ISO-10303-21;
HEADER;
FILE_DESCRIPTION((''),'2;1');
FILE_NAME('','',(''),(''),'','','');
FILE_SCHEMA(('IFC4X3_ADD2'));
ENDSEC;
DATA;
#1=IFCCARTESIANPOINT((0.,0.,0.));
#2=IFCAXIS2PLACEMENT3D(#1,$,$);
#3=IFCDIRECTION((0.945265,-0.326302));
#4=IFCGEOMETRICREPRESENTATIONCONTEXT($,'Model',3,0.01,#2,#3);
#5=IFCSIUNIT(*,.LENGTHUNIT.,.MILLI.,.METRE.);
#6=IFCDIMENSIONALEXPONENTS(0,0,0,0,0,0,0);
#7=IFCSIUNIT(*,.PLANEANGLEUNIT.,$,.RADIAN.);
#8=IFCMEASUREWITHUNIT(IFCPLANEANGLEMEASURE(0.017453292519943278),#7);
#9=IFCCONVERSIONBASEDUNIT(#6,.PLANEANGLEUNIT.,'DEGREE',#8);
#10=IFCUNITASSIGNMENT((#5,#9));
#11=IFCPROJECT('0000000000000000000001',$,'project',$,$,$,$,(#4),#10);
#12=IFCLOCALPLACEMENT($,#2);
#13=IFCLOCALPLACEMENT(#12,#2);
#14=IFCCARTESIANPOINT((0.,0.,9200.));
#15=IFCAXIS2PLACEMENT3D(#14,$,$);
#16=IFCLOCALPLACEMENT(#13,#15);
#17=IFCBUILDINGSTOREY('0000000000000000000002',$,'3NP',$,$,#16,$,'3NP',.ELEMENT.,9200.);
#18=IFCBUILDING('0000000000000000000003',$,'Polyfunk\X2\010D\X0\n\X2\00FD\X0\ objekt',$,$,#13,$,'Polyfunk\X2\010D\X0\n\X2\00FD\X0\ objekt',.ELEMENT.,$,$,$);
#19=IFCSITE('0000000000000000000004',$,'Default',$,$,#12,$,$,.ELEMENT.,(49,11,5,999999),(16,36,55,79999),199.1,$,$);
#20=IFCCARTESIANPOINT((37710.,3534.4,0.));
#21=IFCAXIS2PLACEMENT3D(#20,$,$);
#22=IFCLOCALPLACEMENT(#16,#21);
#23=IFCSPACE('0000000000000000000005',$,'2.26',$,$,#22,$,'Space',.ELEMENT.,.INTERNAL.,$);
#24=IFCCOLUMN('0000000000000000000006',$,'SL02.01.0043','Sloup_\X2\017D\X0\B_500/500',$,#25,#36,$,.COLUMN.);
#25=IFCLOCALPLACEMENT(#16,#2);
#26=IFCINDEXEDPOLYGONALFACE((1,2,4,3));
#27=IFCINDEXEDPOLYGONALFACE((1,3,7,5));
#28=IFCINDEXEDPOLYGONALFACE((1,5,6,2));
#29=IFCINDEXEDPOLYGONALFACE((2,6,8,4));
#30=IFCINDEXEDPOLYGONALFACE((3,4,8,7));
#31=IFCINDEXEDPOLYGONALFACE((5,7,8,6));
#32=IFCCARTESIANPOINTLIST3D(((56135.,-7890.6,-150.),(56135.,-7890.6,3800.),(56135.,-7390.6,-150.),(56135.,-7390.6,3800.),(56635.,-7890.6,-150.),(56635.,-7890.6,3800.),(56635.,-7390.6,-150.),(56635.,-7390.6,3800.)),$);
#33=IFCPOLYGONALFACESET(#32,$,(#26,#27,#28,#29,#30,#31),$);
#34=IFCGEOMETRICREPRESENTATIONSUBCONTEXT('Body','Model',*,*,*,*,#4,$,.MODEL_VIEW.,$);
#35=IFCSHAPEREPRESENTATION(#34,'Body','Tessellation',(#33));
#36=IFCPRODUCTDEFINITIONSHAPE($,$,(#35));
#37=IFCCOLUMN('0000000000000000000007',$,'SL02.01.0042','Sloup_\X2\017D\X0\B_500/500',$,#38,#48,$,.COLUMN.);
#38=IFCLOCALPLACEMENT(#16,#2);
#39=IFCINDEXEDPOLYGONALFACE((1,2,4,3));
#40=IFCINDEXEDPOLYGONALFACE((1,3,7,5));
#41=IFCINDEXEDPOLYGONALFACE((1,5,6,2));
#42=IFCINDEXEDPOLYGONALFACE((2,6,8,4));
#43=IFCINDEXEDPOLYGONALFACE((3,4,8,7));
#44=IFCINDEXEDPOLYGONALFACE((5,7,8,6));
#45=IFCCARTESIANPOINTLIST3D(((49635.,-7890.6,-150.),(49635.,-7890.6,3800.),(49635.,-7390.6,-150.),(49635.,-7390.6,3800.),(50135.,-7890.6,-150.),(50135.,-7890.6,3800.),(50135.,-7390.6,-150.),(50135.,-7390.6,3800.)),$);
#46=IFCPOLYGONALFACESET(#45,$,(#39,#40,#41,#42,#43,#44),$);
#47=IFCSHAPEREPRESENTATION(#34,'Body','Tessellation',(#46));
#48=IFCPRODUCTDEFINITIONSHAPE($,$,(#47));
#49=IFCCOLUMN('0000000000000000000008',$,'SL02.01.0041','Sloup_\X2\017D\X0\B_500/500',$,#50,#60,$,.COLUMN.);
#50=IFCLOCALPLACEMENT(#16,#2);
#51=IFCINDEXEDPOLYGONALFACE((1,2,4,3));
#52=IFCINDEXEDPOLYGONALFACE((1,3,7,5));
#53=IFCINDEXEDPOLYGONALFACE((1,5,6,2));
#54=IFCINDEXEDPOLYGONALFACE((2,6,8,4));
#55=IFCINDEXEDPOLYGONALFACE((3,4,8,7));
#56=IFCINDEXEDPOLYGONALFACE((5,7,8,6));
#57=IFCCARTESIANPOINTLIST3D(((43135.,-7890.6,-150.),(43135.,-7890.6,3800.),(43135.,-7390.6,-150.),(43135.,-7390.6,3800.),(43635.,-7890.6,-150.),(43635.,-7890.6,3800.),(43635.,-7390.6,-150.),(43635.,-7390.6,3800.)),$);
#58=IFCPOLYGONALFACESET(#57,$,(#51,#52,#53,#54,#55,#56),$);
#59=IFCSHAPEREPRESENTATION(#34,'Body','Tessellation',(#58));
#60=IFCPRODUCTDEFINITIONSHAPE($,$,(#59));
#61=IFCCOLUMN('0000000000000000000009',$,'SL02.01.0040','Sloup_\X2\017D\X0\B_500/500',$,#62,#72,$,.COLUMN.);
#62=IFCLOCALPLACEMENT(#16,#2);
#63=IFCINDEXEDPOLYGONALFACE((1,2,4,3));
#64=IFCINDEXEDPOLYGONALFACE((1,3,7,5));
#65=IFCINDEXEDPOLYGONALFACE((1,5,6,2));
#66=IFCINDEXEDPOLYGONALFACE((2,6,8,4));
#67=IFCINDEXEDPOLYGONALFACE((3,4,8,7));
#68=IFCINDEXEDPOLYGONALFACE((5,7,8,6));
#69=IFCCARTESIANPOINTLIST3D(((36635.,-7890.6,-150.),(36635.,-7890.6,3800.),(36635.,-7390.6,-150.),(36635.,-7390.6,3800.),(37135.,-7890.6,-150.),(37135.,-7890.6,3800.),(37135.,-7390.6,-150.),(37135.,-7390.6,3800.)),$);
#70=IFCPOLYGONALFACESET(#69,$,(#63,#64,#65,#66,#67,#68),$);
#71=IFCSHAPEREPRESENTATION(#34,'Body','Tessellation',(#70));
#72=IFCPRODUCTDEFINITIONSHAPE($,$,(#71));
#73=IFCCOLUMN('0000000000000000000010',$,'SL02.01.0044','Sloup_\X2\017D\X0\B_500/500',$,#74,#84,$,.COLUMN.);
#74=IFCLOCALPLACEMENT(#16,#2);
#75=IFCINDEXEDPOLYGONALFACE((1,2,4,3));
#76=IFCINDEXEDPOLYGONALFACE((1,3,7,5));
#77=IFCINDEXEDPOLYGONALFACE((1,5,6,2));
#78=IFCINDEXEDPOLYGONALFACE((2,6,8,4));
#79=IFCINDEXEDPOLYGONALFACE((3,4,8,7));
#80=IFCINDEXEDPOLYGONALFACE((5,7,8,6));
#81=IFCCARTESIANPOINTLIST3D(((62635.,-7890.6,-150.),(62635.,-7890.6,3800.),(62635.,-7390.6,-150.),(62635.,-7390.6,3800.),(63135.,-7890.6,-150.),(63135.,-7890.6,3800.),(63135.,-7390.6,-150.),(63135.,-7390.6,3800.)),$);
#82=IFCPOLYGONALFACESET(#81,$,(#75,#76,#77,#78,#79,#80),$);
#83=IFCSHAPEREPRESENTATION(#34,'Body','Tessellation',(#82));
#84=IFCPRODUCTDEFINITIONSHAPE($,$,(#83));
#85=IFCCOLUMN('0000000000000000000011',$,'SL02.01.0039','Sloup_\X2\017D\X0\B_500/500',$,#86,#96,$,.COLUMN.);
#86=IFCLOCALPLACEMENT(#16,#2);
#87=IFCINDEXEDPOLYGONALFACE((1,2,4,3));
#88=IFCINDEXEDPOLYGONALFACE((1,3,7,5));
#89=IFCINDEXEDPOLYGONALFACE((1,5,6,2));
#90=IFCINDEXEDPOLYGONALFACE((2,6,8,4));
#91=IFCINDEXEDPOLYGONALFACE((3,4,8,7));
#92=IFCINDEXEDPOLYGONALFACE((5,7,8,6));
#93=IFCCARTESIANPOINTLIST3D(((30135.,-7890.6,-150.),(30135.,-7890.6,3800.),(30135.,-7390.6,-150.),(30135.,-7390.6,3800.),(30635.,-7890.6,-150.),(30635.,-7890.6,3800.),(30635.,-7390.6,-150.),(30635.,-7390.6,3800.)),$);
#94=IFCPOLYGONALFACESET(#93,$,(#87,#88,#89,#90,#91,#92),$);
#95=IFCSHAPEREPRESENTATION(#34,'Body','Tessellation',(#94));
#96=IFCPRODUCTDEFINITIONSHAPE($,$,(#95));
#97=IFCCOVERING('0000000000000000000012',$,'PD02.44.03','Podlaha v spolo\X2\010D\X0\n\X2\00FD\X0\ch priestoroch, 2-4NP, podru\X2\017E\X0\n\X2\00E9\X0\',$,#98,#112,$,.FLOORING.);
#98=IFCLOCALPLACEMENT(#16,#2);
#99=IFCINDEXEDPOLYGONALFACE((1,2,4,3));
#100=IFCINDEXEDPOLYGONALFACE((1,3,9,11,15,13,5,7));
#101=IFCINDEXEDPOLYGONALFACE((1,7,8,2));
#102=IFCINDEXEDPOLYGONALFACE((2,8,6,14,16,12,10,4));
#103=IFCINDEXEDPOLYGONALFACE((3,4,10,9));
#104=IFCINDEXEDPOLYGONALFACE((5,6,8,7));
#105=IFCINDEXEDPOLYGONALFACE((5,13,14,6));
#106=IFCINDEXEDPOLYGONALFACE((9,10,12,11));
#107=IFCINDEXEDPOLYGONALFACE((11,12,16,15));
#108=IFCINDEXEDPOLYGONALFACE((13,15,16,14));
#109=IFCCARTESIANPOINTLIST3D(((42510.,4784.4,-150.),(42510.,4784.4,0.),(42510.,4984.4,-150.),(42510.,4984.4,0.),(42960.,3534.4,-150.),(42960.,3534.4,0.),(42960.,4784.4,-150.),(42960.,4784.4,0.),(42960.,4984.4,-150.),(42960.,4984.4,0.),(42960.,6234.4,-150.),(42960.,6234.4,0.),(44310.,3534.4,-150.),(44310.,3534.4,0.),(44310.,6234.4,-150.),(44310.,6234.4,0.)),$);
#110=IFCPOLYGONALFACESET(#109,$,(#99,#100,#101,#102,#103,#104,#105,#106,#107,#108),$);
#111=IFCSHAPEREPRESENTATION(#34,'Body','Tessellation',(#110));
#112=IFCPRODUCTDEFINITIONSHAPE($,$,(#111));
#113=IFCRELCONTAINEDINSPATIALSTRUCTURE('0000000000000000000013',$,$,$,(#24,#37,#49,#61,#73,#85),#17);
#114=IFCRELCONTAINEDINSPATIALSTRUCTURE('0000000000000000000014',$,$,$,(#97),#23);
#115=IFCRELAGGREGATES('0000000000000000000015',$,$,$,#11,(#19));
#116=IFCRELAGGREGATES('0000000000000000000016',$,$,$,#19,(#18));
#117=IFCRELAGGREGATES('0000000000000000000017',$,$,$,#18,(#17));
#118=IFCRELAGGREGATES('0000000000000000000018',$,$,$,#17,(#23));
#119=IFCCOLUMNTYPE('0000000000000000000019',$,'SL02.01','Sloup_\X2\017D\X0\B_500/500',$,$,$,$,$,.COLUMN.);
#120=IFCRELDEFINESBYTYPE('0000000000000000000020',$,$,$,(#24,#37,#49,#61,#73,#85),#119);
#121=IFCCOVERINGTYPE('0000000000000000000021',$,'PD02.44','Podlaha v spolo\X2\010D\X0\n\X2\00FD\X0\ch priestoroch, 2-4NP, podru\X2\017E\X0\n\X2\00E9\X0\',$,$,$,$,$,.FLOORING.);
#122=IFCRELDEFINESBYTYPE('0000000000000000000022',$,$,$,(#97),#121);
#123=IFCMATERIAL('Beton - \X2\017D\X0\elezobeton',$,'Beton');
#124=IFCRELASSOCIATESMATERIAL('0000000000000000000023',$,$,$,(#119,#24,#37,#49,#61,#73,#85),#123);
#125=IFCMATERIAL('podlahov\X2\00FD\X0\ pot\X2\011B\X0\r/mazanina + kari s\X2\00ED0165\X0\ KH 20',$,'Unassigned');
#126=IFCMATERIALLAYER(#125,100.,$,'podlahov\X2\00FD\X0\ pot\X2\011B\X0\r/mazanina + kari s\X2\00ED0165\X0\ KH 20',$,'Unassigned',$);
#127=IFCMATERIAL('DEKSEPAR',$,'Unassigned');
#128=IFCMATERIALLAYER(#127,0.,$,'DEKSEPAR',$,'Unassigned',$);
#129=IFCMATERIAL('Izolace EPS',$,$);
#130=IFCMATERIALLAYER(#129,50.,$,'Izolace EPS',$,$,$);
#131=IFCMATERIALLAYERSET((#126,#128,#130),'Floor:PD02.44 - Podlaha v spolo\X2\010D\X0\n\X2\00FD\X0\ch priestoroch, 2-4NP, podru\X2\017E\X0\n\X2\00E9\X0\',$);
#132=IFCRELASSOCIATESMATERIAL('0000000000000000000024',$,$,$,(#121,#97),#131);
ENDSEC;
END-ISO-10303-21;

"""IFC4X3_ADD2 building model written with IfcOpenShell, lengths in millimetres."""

from ifc_helpers import new_model, entity, si_unit, converted_unit, direction, frame, frame_2d, origin, origin_2d_with_axis, place, context, subcontext, project, spatial, polyline, rectangle, outline, extrude, source, transform, mapped, material, layer, layer_set, layer_usage, material_profile, profile_set, profile_usage, type_object, element, save


model = new_model("IFC4X3_ADD2")

# Units and contexts
model_context = context("Model", 3, precision=0.01, world=origin(), true_north=direction((0.945265, -0.326302)))
body_context = subcontext(model_context, "Body", "Model", "MODEL_VIEW")
ifc_project = project(units=[si_unit("LENGTHUNIT", "METRE", prefix="MILLI"), converted_unit("PLANEANGLEUNIT", "DEGREE", entity("IfcPlaneAngleMeasure", 0.017453292519943278), si_unit("PLANEANGLEUNIT", "RADIAN"), dimensions=[0, 0, 0, 0, 0, 0, 0])], contexts=[model_context])

# Site, building, storey
site_placement = place(None, origin())
site = spatial("IfcSite", under=ifc_project, at=site_placement, Name="Default", CompositionType="ELEMENT", RefLatitude=(49, 11, 5, 999999), RefLongitude=(16, 36, 55, 79999), RefElevation=199.1)
building_placement = place(site_placement, origin())
building = spatial("IfcBuilding", under=site, at=building_placement, Name="Polyfunkčný objekt", LongName="Polyfunkčný objekt", CompositionType="ELEMENT")
storey_placement = place(building_placement, frame((0.0, 0.0, 9200.0)))
storey = spatial("IfcBuildingStorey", under=building, at=storey_placement, Name="3NP", LongName="3NP", CompositionType="ELEMENT", Elevation=9200.0)

# Columns
ifc_material_1 = material(Name="Beton - Železobeton", Category="Beton")
ifc_material_profile_1 = material_profile(ifc_material_1, rectangle(XDim=500.0, YDim=500.0, at=frame_2d((0.0, 0.0), x_axis=(1.0, 0.0))), Name="Sloup_ŽB_500/500")
ifc_profile_set_1 = profile_set([ifc_material_profile_1], Name="Sloup_ŽB_500/500")
ifc_profile_usage_1 = profile_usage(ifc_profile_set_1)
column_type_1 = type_object("IfcColumnType", Name="SL02.01", Description="Sloup_ŽB_500/500", PredefinedType="COLUMN", material=ifc_profile_set_1)
shared_shape_1 = source(origin(), body_context, "Body", "SweptSolid", [
    extrude(rectangle(XDim=500.0, YDim=500.0, at=origin_2d_with_axis()), frame((56385.0, -7640.6, 9050.0)), (0.0, 0.0, 1.0), 3950.0),
])
column_1_placement = place(storey_placement, frame((0.0, 0.0, -9200.0)))
element("IfcColumn", 1, at=column_1_placement, inside=storey, type_object=column_type_1, material=ifc_profile_usage_1, Name="SL02.01.0043", Description="Sloup_ŽB_500/500", PredefinedType="COLUMN", context=body_context, shape_type="MappedRepresentation", body=[
    mapped(shared_shape_1, transform((0.0, 0.0, 0.0), scale=1.0)),
])
shared_shape_2 = source(origin(), body_context, "Body", "SweptSolid", [
    extrude(rectangle(XDim=500.0, YDim=500.0, at=frame_2d((0.0, 0.0), x_axis=(1.0, 0.0))), frame((49885.0, -7640.6, 9050.0)), (0.0, 0.0, 1.0), 3950.0),
])
column_2_placement = place(storey_placement, frame((0.0, 0.0, -9200.0)))
element("IfcColumn", 2, at=column_2_placement, inside=storey, type_object=column_type_1, material=ifc_profile_usage_1, Name="SL02.01.0042", Description="Sloup_ŽB_500/500", PredefinedType="COLUMN", context=body_context, shape_type="MappedRepresentation", body=[
    mapped(shared_shape_2, transform((0.0, 0.0, 0.0), scale=1.0)),
])
shared_shape_3 = source(origin(), body_context, "Body", "SweptSolid", [
    extrude(rectangle(XDim=500.0, YDim=500.0, at=origin_2d_with_axis()), frame((43385.0, -7640.6, 9050.0)), (0.0, 0.0, 1.0), 3950.0),
])
column_3_placement = place(storey_placement, frame((0.0, 0.0, -9200.0)))
element("IfcColumn", 3, at=column_3_placement, inside=storey, type_object=column_type_1, material=ifc_profile_usage_1, Name="SL02.01.0041", Description="Sloup_ŽB_500/500", PredefinedType="COLUMN", context=body_context, shape_type="MappedRepresentation", body=[
    mapped(shared_shape_3, transform((0.0, 0.0, 0.0), scale=1.0)),
])
shared_shape_4 = source(origin(), body_context, "Body", "SweptSolid", [
    extrude(rectangle(XDim=500.0, YDim=500.0, at=origin_2d_with_axis()), frame((36885.0, -7640.6, 9050.0)), (0.0, 0.0, 1.0), 3950.0),
])
column_4_placement = place(storey_placement, frame((0.0, 0.0, -9200.0)))
element("IfcColumn", 4, at=column_4_placement, inside=storey, type_object=column_type_1, material=ifc_profile_usage_1, Name="SL02.01.0040", Description="Sloup_ŽB_500/500", PredefinedType="COLUMN", context=body_context, shape_type="MappedRepresentation", body=[
    mapped(shared_shape_4, transform((0.0, 0.0, 0.0), scale=1.0)),
])
shared_shape_5 = source(origin(), body_context, "Body", "SweptSolid", [
    extrude(rectangle(XDim=500.0, YDim=500.0, at=frame_2d((0.0, 0.0), x_axis=(1.0, 0.0))), frame((62885.0, -7640.6, 9050.0), z_axis=(0.0, 0.0, 1.0), x_axis=(-1.0, 0.0, 0.0)), (0.0, 0.0, 1.0), 3950.0),
])
column_5_placement = place(storey_placement, frame((0.0, 0.0, -9200.0)))
element("IfcColumn", 5, at=column_5_placement, inside=storey, type_object=column_type_1, material=ifc_profile_usage_1, Name="SL02.01.0044", Description="Sloup_ŽB_500/500", PredefinedType="COLUMN", context=body_context, shape_type="MappedRepresentation", body=[
    mapped(shared_shape_5, transform((0.0, 0.0, 0.0), scale=1.0)),
])
shared_shape_6 = source(origin(), body_context, "Body", "SweptSolid", [
    extrude(rectangle(XDim=500.0, YDim=500.0, at=frame_2d((0.0, 0.0), x_axis=(1.0, 0.0))), frame((30385.0, -7640.6, 9050.0), z_axis=(0.0, 0.0, 1.0), x_axis=(-1.0, 0.0, 0.0)), (0.0, 0.0, 1.0), 3950.0),
])
column_6_placement = place(storey_placement, frame((0.0, 0.0, -9200.0)))
element("IfcColumn", 6, at=column_6_placement, inside=storey, type_object=column_type_1, material=ifc_profile_usage_1, Name="SL02.01.0039", Description="Sloup_ŽB_500/500", PredefinedType="COLUMN", context=body_context, shape_type="MappedRepresentation", body=[
    mapped(shared_shape_6, transform((0.0, 0.0, 0.0), scale=1.0)),
])

# Shared definitions
space_1_placement = place(storey_placement, frame((37710.0, 3534.4, 0.0)))
space_1 = spatial("IfcSpace", under=storey, at=space_1_placement, Name="2.26", LongName="Space", CompositionType="ELEMENT", PredefinedType="INTERNAL")

# Covering
ifc_material_2 = material(Name="podlahový potěr/mazanina + kari síť KH 20", Category="Unassigned")
ifc_layer_1 = layer(ifc_material_2, 100.0, Name="podlahový potěr/mazanina + kari síť KH 20", Category="Unassigned")
ifc_material_3 = material(Name="DEKSEPAR", Category="Unassigned")
ifc_layer_2 = layer(ifc_material_3, 0.0, Name="DEKSEPAR", Category="Unassigned")
ifc_material_4 = material(Name="Izolace EPS")
ifc_layer_3 = layer(ifc_material_4, 50.0, Name="Izolace EPS")
ifc_layer_set_1 = layer_set([ifc_layer_1, ifc_layer_2, ifc_layer_3], Name="Floor:PD02.44 - Podlaha v spoločných priestoroch, 2-4NP, podružné")
ifc_layer_usage_1 = layer_usage(ifc_layer_set_1, "AXIS3", "POSITIVE", 0.0)
covering_type_1 = type_object("IfcCoveringType", Name="PD02.44", Description="Podlaha v spoločných priestoroch, 2-4NP, podružné", PredefinedType="FLOORING", material=ifc_layer_set_1)
covering_1_placement = place(storey_placement, origin())
element("IfcCovering", 7, at=covering_1_placement, inside=space_1, type_object=covering_type_1, material=ifc_layer_usage_1, Name="PD02.44.03", Description="Podlaha v spoločných priestoroch, 2-4NP, podružné", PredefinedType="FLOORING", context=body_context, shape_type="SweptSolid", body=[
    extrude(outline(polyline([(-100.0, -675.0), (100.0, -675.0), (100.0, -225.0), (1350.0, -225.0), (1350.0, 1125.0), (-1350.0, 1125.0), (-1350.0, -225.0), (-100.0, -225.0), (-100.0, -675.0)])), frame((43185.0, 4884.4, 0.0), z_axis=(0.0, 0.0, -1.0), x_axis=(0.0, 1.0, 0.0)), (0.0, 0.0, 1.0), 150.0),
])

save(model, "model.ifc")
